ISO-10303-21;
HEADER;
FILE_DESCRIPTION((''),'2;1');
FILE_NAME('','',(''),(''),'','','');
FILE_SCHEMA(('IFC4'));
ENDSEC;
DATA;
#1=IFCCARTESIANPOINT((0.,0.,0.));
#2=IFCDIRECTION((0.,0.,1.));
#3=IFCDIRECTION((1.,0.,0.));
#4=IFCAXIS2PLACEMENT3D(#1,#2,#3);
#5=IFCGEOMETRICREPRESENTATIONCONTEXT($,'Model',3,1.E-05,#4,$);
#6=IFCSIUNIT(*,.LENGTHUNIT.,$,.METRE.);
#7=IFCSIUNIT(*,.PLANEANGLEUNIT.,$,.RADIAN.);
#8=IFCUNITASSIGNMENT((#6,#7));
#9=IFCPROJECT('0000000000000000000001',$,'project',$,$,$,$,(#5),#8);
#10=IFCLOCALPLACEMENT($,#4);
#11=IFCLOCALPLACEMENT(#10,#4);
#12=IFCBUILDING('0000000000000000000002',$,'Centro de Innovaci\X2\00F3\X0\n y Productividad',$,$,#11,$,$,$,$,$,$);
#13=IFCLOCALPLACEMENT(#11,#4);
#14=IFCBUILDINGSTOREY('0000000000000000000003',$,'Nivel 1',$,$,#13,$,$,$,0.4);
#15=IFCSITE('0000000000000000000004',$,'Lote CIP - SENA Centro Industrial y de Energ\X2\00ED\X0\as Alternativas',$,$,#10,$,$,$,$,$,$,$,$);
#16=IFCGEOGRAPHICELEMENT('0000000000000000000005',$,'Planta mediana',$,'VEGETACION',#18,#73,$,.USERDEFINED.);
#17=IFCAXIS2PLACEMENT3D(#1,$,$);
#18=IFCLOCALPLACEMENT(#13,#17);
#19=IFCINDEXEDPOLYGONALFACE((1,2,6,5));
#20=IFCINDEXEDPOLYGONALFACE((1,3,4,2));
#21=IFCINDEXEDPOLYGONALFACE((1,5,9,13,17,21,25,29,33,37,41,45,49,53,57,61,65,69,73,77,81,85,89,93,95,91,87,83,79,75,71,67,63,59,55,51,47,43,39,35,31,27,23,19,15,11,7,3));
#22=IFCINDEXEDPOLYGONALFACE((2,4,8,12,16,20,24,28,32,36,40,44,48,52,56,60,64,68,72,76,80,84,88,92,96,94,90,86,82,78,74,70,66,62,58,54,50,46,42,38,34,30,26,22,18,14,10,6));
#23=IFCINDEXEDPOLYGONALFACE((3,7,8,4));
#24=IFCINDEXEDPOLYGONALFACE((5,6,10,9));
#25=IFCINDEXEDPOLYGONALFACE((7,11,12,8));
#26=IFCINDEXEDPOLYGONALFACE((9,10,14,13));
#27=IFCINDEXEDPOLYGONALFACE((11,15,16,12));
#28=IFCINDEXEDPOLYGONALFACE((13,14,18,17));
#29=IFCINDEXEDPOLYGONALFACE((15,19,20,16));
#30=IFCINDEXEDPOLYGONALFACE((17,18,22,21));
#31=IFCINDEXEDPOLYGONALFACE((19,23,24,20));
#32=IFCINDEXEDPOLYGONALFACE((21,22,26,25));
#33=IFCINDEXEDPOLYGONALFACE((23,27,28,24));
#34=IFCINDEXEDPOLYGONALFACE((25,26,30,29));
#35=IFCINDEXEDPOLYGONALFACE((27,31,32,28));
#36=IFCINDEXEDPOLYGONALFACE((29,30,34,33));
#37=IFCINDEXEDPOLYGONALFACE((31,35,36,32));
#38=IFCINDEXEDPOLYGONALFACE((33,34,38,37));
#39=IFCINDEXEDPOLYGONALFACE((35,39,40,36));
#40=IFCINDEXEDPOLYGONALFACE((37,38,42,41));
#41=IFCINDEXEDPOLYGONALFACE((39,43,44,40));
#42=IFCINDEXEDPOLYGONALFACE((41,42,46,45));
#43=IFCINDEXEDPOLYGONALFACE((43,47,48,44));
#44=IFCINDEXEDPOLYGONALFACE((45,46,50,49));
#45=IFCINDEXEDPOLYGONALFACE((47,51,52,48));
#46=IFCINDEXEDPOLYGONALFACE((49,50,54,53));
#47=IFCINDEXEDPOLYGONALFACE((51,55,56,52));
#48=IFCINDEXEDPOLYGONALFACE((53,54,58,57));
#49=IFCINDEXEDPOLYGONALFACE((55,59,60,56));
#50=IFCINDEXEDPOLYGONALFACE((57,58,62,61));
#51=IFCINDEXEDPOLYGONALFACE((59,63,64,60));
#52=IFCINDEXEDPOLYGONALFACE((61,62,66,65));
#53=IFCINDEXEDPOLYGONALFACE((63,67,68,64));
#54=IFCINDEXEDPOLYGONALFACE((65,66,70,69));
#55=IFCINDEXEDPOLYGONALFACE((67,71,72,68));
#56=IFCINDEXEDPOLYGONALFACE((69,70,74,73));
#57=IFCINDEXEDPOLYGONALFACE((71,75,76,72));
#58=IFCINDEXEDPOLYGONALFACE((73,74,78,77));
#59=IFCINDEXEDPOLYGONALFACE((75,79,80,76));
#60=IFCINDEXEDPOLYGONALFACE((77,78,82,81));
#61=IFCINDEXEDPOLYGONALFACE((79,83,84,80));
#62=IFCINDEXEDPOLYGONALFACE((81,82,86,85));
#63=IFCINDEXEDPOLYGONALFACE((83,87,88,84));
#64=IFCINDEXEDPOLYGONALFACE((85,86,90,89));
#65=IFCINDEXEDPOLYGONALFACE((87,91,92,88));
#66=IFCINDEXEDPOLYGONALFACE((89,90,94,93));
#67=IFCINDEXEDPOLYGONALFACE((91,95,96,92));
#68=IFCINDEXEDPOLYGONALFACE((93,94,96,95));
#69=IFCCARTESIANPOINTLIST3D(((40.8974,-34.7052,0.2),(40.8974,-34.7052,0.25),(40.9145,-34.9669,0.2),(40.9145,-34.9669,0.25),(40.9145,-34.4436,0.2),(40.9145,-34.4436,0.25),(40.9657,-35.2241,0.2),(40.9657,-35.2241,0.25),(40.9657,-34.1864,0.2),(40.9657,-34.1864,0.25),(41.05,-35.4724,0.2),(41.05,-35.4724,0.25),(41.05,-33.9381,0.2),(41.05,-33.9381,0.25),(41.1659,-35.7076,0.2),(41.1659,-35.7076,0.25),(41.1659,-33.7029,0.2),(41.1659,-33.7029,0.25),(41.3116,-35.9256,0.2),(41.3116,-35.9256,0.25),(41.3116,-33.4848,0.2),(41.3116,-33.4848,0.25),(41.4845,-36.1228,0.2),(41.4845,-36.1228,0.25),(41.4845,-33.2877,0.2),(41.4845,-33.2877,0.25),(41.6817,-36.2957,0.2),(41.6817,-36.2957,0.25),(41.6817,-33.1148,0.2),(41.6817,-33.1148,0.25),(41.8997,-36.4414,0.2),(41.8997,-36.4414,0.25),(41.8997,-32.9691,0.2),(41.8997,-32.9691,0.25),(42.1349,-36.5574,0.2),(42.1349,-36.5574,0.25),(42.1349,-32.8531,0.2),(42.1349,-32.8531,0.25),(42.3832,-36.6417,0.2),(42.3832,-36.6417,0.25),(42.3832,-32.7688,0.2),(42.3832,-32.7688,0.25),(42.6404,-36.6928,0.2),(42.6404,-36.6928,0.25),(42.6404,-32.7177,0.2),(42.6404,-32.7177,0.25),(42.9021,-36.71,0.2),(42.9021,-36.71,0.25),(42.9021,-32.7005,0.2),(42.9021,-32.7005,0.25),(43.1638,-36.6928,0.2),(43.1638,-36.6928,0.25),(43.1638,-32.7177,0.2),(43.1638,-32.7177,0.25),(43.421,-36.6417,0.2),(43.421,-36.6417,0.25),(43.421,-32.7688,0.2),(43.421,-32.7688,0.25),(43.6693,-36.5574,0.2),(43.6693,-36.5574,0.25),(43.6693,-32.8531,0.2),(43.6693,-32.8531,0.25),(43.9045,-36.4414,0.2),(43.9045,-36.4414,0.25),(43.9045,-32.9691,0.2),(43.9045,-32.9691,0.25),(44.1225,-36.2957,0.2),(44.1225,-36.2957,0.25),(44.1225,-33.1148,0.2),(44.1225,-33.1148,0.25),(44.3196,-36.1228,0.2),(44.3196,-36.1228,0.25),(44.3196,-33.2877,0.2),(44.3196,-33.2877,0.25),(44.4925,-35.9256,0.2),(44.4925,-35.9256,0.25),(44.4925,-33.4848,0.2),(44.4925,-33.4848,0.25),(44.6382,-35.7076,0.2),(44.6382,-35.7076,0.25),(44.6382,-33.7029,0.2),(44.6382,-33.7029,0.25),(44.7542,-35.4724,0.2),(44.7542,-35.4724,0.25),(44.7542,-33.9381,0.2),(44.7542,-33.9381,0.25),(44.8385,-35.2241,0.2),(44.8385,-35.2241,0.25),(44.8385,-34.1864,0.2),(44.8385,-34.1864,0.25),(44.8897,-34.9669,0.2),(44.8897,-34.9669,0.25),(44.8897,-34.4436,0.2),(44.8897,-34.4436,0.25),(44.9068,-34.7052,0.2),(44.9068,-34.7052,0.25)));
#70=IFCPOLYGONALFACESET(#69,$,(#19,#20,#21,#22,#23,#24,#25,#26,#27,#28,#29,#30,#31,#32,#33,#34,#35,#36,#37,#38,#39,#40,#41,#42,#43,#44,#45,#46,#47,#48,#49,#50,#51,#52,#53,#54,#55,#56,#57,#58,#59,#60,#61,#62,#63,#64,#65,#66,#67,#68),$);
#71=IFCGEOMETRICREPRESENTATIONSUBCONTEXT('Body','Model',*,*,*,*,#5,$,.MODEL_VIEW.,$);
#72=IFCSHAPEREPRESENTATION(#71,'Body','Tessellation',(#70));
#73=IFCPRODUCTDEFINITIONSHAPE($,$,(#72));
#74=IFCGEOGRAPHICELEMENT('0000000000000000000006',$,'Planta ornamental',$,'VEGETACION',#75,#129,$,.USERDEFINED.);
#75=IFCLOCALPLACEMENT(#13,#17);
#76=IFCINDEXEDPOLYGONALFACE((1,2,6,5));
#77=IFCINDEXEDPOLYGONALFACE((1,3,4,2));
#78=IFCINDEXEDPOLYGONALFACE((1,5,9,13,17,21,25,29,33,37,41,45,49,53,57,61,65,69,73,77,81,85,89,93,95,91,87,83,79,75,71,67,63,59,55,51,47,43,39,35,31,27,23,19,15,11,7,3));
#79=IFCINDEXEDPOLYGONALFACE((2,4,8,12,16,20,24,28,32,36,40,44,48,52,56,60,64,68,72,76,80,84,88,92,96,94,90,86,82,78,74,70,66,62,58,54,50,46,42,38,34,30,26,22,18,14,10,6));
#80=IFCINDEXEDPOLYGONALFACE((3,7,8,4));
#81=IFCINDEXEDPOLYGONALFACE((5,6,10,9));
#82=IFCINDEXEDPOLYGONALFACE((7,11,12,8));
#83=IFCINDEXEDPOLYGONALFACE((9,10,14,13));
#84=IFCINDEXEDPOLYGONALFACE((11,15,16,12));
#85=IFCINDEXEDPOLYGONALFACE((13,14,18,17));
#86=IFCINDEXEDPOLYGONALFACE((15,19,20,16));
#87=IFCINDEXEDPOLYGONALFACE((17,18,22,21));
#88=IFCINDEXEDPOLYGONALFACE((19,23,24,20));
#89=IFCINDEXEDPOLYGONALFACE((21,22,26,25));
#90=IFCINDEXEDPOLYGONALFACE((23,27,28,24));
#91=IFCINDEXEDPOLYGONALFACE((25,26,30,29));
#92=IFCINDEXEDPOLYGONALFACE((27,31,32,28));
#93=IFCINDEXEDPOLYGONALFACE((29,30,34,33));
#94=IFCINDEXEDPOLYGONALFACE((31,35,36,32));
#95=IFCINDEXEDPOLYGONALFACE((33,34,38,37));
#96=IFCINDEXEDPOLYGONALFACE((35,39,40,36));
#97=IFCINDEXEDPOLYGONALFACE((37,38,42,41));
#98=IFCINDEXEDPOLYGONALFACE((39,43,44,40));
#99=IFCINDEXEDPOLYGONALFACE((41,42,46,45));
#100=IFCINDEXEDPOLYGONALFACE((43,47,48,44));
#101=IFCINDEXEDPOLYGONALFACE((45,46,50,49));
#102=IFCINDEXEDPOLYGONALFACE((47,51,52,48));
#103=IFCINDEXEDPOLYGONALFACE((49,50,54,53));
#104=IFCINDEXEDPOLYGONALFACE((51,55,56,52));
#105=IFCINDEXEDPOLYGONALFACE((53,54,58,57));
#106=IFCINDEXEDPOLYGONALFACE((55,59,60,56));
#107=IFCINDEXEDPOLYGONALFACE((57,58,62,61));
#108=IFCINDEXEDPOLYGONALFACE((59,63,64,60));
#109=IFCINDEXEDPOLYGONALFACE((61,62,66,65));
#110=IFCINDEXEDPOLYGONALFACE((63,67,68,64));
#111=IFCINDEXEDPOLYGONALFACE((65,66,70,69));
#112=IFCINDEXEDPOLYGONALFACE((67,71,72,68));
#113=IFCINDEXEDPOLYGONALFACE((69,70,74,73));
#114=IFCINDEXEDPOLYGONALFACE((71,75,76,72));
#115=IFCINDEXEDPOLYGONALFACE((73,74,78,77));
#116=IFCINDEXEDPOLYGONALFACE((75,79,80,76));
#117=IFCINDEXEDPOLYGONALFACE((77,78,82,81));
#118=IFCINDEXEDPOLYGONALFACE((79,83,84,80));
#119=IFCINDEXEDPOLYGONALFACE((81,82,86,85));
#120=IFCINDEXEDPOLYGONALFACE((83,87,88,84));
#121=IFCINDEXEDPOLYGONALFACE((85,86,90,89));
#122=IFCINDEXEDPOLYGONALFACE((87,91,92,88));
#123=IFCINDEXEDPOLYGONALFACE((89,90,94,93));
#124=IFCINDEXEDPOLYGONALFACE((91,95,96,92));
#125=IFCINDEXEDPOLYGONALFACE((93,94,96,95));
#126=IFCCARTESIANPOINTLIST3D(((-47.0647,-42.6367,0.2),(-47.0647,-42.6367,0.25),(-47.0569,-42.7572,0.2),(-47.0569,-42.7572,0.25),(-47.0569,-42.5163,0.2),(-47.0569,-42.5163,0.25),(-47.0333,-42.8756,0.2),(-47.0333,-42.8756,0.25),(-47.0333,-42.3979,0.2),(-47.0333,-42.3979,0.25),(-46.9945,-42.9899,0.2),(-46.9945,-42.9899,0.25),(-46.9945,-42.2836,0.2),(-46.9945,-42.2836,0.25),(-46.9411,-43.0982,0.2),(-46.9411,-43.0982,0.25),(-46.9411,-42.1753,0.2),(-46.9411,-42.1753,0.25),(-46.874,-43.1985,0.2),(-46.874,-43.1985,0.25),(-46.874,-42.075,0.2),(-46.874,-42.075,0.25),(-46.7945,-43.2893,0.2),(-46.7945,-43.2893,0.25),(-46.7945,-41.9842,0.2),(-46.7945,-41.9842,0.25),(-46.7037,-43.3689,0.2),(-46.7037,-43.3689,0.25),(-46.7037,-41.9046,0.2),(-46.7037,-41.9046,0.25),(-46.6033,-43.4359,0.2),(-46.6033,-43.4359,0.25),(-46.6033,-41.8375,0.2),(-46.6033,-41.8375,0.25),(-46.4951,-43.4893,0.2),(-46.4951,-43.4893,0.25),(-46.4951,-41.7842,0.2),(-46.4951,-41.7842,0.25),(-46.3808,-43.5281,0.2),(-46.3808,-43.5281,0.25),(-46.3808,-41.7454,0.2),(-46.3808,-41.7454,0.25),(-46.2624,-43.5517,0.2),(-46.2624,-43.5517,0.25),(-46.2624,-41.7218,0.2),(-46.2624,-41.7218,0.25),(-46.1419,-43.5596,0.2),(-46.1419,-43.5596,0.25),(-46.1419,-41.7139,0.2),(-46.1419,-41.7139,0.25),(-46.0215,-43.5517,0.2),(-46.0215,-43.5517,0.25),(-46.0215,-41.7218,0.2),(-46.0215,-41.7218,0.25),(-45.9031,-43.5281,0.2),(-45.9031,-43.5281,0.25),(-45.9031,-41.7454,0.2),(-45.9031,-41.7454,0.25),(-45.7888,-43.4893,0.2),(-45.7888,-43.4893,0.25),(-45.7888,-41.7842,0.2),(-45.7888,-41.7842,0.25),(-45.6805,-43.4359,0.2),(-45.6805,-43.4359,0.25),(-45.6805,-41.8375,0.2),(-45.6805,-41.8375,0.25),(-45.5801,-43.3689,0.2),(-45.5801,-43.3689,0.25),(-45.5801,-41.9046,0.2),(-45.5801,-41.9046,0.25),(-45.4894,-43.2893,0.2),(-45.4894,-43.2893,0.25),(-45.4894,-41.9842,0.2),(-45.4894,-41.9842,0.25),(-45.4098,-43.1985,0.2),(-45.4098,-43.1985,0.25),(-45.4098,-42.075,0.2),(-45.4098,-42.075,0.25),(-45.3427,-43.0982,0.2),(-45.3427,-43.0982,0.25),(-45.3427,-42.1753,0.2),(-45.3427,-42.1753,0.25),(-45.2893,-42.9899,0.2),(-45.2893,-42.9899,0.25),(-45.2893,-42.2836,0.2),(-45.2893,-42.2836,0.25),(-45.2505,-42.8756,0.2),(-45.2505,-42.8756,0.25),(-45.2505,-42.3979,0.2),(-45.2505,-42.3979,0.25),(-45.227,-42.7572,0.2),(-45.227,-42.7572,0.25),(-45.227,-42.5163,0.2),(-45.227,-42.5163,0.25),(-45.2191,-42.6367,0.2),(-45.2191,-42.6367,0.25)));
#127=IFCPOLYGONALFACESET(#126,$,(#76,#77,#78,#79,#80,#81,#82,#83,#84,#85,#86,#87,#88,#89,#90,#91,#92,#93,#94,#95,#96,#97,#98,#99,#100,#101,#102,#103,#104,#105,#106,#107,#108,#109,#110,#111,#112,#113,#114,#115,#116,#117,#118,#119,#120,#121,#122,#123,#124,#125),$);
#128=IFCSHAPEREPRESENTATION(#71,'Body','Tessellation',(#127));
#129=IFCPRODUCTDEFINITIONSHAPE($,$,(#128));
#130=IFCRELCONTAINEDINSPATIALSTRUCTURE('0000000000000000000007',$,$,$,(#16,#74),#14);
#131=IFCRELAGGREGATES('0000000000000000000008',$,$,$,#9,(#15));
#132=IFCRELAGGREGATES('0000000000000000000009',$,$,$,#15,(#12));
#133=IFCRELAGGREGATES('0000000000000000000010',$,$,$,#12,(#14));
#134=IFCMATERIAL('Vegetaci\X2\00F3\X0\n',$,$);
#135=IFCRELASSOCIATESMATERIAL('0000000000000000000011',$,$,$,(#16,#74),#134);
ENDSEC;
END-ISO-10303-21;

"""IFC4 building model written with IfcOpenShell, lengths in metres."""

from ifc_helpers import new_model, si_unit, frame, origin_with_axes, place, context, subcontext, project, spatial, polyline, outline, extrude, material, element, save


model = new_model("IFC4")

# Units and contexts
model_context = context("Model", 3, precision=1e-05, world=origin_with_axes())
body_context = subcontext(model_context, "Body", "Model", "MODEL_VIEW")
ifc_project = project(units=[si_unit("LENGTHUNIT", "METRE"), si_unit("PLANEANGLEUNIT", "RADIAN")], contexts=[model_context])

# Site, building, storey
site_placement = place(None, origin_with_axes())
site = spatial("IfcSite", under=ifc_project, at=site_placement, Name="Lote CIP - SENA Centro Industrial y de Energías Alternativas")
building_placement = place(site_placement, origin_with_axes())
building = spatial("IfcBuilding", under=site, at=building_placement, Name="Centro de Innovación y Productividad")
storey_placement = place(building_placement, origin_with_axes())
storey = spatial("IfcBuildingStorey", under=building, at=storey_placement, Name="Nivel 1", Elevation=0.4)

# Geographic elements
ifc_material_1 = material(Name="Vegetación")
geographic_element_1_placement = place(storey_placement, origin_with_axes())
element("IfcGeographicElement", 1, at=geographic_element_1_placement, inside=storey, material=ifc_material_1, Name="Planta mediana", ObjectType="VEGETACION", PredefinedType="USERDEFINED", context=body_context, shape_type="SweptSolid", body=[
    extrude(outline(polyline([(44.9068, -34.7052), (44.8897, -34.9669), (44.8385, -35.2241), (44.7542, -35.4724), (44.6382, -35.7076), (44.4925, -35.9256), (44.3196, -36.1228), (44.1225, -36.2957), (43.9045, -36.4414), (43.6693, -36.5574), (43.421, -36.6417), (43.1638, -36.6928), (42.9021, -36.71), (42.6404, -36.6928), (42.3832, -36.6417), (42.1349, -36.5574), (41.8997, -36.4414), (41.6817, -36.2957), (41.4845, -36.1228), (41.3116, -35.9256), (41.1659, -35.7076), (41.05, -35.4724), (40.9657, -35.2241), (40.9145, -34.9669), (40.8974, -34.7052), (40.9145, -34.4436), (40.9657, -34.1864), (41.05, -33.9381), (41.1659, -33.7029), (41.3116, -33.4848), (41.4845, -33.2877), (41.6817, -33.1148), (41.8997, -32.9691), (42.1349, -32.8531), (42.3832, -32.7688), (42.6404, -32.7177), (42.9021, -32.7005), (43.1638, -32.7177), (43.421, -32.7688), (43.6693, -32.8531), (43.9045, -32.9691), (44.1225, -33.1148), (44.3196, -33.2877), (44.4925, -33.4848), (44.6382, -33.7029), (44.7542, -33.9381), (44.8385, -34.1864), (44.8897, -34.4436), (44.9068, -34.7052)])), frame((0.0, 0.0, 0.2)), (0.0, 0.0, 1.0), 0.05),
])
geographic_element_2_placement = place(storey_placement, origin_with_axes())
element("IfcGeographicElement", 2, at=geographic_element_2_placement, inside=storey, material=ifc_material_1, Name="Planta ornamental", ObjectType="VEGETACION", PredefinedType="USERDEFINED", context=body_context, shape_type="SweptSolid", body=[
    extrude(outline(polyline([(-45.2191, -42.6367), (-45.227, -42.7572), (-45.2505, -42.8756), (-45.2893, -42.9899), (-45.3427, -43.0982), (-45.4098, -43.1985), (-45.4894, -43.2893), (-45.5801, -43.3689), (-45.6805, -43.4359), (-45.7888, -43.4893), (-45.9031, -43.5281), (-46.0215, -43.5517), (-46.1419, -43.5596), (-46.2624, -43.5517), (-46.3808, -43.5281), (-46.4951, -43.4893), (-46.6033, -43.4359), (-46.7037, -43.3689), (-46.7945, -43.2893), (-46.874, -43.1985), (-46.9411, -43.0982), (-46.9945, -42.9899), (-47.0333, -42.8756), (-47.0569, -42.7572), (-47.0647, -42.6367), (-47.0569, -42.5163), (-47.0333, -42.3979), (-46.9945, -42.2836), (-46.9411, -42.1753), (-46.874, -42.075), (-46.7945, -41.9842), (-46.7037, -41.9046), (-46.6033, -41.8375), (-46.4951, -41.7842), (-46.3808, -41.7454), (-46.2624, -41.7218), (-46.1419, -41.7139), (-46.0215, -41.7218), (-45.9031, -41.7454), (-45.7888, -41.7842), (-45.6805, -41.8375), (-45.5801, -41.9046), (-45.4894, -41.9842), (-45.4098, -42.075), (-45.3427, -42.1753), (-45.2893, -42.2836), (-45.2505, -42.3979), (-45.227, -42.5163), (-45.2191, -42.6367)])), frame((0.0, 0.0, 0.2)), (0.0, 0.0, 1.0), 0.05),
])

save(model, "model.ifc")
